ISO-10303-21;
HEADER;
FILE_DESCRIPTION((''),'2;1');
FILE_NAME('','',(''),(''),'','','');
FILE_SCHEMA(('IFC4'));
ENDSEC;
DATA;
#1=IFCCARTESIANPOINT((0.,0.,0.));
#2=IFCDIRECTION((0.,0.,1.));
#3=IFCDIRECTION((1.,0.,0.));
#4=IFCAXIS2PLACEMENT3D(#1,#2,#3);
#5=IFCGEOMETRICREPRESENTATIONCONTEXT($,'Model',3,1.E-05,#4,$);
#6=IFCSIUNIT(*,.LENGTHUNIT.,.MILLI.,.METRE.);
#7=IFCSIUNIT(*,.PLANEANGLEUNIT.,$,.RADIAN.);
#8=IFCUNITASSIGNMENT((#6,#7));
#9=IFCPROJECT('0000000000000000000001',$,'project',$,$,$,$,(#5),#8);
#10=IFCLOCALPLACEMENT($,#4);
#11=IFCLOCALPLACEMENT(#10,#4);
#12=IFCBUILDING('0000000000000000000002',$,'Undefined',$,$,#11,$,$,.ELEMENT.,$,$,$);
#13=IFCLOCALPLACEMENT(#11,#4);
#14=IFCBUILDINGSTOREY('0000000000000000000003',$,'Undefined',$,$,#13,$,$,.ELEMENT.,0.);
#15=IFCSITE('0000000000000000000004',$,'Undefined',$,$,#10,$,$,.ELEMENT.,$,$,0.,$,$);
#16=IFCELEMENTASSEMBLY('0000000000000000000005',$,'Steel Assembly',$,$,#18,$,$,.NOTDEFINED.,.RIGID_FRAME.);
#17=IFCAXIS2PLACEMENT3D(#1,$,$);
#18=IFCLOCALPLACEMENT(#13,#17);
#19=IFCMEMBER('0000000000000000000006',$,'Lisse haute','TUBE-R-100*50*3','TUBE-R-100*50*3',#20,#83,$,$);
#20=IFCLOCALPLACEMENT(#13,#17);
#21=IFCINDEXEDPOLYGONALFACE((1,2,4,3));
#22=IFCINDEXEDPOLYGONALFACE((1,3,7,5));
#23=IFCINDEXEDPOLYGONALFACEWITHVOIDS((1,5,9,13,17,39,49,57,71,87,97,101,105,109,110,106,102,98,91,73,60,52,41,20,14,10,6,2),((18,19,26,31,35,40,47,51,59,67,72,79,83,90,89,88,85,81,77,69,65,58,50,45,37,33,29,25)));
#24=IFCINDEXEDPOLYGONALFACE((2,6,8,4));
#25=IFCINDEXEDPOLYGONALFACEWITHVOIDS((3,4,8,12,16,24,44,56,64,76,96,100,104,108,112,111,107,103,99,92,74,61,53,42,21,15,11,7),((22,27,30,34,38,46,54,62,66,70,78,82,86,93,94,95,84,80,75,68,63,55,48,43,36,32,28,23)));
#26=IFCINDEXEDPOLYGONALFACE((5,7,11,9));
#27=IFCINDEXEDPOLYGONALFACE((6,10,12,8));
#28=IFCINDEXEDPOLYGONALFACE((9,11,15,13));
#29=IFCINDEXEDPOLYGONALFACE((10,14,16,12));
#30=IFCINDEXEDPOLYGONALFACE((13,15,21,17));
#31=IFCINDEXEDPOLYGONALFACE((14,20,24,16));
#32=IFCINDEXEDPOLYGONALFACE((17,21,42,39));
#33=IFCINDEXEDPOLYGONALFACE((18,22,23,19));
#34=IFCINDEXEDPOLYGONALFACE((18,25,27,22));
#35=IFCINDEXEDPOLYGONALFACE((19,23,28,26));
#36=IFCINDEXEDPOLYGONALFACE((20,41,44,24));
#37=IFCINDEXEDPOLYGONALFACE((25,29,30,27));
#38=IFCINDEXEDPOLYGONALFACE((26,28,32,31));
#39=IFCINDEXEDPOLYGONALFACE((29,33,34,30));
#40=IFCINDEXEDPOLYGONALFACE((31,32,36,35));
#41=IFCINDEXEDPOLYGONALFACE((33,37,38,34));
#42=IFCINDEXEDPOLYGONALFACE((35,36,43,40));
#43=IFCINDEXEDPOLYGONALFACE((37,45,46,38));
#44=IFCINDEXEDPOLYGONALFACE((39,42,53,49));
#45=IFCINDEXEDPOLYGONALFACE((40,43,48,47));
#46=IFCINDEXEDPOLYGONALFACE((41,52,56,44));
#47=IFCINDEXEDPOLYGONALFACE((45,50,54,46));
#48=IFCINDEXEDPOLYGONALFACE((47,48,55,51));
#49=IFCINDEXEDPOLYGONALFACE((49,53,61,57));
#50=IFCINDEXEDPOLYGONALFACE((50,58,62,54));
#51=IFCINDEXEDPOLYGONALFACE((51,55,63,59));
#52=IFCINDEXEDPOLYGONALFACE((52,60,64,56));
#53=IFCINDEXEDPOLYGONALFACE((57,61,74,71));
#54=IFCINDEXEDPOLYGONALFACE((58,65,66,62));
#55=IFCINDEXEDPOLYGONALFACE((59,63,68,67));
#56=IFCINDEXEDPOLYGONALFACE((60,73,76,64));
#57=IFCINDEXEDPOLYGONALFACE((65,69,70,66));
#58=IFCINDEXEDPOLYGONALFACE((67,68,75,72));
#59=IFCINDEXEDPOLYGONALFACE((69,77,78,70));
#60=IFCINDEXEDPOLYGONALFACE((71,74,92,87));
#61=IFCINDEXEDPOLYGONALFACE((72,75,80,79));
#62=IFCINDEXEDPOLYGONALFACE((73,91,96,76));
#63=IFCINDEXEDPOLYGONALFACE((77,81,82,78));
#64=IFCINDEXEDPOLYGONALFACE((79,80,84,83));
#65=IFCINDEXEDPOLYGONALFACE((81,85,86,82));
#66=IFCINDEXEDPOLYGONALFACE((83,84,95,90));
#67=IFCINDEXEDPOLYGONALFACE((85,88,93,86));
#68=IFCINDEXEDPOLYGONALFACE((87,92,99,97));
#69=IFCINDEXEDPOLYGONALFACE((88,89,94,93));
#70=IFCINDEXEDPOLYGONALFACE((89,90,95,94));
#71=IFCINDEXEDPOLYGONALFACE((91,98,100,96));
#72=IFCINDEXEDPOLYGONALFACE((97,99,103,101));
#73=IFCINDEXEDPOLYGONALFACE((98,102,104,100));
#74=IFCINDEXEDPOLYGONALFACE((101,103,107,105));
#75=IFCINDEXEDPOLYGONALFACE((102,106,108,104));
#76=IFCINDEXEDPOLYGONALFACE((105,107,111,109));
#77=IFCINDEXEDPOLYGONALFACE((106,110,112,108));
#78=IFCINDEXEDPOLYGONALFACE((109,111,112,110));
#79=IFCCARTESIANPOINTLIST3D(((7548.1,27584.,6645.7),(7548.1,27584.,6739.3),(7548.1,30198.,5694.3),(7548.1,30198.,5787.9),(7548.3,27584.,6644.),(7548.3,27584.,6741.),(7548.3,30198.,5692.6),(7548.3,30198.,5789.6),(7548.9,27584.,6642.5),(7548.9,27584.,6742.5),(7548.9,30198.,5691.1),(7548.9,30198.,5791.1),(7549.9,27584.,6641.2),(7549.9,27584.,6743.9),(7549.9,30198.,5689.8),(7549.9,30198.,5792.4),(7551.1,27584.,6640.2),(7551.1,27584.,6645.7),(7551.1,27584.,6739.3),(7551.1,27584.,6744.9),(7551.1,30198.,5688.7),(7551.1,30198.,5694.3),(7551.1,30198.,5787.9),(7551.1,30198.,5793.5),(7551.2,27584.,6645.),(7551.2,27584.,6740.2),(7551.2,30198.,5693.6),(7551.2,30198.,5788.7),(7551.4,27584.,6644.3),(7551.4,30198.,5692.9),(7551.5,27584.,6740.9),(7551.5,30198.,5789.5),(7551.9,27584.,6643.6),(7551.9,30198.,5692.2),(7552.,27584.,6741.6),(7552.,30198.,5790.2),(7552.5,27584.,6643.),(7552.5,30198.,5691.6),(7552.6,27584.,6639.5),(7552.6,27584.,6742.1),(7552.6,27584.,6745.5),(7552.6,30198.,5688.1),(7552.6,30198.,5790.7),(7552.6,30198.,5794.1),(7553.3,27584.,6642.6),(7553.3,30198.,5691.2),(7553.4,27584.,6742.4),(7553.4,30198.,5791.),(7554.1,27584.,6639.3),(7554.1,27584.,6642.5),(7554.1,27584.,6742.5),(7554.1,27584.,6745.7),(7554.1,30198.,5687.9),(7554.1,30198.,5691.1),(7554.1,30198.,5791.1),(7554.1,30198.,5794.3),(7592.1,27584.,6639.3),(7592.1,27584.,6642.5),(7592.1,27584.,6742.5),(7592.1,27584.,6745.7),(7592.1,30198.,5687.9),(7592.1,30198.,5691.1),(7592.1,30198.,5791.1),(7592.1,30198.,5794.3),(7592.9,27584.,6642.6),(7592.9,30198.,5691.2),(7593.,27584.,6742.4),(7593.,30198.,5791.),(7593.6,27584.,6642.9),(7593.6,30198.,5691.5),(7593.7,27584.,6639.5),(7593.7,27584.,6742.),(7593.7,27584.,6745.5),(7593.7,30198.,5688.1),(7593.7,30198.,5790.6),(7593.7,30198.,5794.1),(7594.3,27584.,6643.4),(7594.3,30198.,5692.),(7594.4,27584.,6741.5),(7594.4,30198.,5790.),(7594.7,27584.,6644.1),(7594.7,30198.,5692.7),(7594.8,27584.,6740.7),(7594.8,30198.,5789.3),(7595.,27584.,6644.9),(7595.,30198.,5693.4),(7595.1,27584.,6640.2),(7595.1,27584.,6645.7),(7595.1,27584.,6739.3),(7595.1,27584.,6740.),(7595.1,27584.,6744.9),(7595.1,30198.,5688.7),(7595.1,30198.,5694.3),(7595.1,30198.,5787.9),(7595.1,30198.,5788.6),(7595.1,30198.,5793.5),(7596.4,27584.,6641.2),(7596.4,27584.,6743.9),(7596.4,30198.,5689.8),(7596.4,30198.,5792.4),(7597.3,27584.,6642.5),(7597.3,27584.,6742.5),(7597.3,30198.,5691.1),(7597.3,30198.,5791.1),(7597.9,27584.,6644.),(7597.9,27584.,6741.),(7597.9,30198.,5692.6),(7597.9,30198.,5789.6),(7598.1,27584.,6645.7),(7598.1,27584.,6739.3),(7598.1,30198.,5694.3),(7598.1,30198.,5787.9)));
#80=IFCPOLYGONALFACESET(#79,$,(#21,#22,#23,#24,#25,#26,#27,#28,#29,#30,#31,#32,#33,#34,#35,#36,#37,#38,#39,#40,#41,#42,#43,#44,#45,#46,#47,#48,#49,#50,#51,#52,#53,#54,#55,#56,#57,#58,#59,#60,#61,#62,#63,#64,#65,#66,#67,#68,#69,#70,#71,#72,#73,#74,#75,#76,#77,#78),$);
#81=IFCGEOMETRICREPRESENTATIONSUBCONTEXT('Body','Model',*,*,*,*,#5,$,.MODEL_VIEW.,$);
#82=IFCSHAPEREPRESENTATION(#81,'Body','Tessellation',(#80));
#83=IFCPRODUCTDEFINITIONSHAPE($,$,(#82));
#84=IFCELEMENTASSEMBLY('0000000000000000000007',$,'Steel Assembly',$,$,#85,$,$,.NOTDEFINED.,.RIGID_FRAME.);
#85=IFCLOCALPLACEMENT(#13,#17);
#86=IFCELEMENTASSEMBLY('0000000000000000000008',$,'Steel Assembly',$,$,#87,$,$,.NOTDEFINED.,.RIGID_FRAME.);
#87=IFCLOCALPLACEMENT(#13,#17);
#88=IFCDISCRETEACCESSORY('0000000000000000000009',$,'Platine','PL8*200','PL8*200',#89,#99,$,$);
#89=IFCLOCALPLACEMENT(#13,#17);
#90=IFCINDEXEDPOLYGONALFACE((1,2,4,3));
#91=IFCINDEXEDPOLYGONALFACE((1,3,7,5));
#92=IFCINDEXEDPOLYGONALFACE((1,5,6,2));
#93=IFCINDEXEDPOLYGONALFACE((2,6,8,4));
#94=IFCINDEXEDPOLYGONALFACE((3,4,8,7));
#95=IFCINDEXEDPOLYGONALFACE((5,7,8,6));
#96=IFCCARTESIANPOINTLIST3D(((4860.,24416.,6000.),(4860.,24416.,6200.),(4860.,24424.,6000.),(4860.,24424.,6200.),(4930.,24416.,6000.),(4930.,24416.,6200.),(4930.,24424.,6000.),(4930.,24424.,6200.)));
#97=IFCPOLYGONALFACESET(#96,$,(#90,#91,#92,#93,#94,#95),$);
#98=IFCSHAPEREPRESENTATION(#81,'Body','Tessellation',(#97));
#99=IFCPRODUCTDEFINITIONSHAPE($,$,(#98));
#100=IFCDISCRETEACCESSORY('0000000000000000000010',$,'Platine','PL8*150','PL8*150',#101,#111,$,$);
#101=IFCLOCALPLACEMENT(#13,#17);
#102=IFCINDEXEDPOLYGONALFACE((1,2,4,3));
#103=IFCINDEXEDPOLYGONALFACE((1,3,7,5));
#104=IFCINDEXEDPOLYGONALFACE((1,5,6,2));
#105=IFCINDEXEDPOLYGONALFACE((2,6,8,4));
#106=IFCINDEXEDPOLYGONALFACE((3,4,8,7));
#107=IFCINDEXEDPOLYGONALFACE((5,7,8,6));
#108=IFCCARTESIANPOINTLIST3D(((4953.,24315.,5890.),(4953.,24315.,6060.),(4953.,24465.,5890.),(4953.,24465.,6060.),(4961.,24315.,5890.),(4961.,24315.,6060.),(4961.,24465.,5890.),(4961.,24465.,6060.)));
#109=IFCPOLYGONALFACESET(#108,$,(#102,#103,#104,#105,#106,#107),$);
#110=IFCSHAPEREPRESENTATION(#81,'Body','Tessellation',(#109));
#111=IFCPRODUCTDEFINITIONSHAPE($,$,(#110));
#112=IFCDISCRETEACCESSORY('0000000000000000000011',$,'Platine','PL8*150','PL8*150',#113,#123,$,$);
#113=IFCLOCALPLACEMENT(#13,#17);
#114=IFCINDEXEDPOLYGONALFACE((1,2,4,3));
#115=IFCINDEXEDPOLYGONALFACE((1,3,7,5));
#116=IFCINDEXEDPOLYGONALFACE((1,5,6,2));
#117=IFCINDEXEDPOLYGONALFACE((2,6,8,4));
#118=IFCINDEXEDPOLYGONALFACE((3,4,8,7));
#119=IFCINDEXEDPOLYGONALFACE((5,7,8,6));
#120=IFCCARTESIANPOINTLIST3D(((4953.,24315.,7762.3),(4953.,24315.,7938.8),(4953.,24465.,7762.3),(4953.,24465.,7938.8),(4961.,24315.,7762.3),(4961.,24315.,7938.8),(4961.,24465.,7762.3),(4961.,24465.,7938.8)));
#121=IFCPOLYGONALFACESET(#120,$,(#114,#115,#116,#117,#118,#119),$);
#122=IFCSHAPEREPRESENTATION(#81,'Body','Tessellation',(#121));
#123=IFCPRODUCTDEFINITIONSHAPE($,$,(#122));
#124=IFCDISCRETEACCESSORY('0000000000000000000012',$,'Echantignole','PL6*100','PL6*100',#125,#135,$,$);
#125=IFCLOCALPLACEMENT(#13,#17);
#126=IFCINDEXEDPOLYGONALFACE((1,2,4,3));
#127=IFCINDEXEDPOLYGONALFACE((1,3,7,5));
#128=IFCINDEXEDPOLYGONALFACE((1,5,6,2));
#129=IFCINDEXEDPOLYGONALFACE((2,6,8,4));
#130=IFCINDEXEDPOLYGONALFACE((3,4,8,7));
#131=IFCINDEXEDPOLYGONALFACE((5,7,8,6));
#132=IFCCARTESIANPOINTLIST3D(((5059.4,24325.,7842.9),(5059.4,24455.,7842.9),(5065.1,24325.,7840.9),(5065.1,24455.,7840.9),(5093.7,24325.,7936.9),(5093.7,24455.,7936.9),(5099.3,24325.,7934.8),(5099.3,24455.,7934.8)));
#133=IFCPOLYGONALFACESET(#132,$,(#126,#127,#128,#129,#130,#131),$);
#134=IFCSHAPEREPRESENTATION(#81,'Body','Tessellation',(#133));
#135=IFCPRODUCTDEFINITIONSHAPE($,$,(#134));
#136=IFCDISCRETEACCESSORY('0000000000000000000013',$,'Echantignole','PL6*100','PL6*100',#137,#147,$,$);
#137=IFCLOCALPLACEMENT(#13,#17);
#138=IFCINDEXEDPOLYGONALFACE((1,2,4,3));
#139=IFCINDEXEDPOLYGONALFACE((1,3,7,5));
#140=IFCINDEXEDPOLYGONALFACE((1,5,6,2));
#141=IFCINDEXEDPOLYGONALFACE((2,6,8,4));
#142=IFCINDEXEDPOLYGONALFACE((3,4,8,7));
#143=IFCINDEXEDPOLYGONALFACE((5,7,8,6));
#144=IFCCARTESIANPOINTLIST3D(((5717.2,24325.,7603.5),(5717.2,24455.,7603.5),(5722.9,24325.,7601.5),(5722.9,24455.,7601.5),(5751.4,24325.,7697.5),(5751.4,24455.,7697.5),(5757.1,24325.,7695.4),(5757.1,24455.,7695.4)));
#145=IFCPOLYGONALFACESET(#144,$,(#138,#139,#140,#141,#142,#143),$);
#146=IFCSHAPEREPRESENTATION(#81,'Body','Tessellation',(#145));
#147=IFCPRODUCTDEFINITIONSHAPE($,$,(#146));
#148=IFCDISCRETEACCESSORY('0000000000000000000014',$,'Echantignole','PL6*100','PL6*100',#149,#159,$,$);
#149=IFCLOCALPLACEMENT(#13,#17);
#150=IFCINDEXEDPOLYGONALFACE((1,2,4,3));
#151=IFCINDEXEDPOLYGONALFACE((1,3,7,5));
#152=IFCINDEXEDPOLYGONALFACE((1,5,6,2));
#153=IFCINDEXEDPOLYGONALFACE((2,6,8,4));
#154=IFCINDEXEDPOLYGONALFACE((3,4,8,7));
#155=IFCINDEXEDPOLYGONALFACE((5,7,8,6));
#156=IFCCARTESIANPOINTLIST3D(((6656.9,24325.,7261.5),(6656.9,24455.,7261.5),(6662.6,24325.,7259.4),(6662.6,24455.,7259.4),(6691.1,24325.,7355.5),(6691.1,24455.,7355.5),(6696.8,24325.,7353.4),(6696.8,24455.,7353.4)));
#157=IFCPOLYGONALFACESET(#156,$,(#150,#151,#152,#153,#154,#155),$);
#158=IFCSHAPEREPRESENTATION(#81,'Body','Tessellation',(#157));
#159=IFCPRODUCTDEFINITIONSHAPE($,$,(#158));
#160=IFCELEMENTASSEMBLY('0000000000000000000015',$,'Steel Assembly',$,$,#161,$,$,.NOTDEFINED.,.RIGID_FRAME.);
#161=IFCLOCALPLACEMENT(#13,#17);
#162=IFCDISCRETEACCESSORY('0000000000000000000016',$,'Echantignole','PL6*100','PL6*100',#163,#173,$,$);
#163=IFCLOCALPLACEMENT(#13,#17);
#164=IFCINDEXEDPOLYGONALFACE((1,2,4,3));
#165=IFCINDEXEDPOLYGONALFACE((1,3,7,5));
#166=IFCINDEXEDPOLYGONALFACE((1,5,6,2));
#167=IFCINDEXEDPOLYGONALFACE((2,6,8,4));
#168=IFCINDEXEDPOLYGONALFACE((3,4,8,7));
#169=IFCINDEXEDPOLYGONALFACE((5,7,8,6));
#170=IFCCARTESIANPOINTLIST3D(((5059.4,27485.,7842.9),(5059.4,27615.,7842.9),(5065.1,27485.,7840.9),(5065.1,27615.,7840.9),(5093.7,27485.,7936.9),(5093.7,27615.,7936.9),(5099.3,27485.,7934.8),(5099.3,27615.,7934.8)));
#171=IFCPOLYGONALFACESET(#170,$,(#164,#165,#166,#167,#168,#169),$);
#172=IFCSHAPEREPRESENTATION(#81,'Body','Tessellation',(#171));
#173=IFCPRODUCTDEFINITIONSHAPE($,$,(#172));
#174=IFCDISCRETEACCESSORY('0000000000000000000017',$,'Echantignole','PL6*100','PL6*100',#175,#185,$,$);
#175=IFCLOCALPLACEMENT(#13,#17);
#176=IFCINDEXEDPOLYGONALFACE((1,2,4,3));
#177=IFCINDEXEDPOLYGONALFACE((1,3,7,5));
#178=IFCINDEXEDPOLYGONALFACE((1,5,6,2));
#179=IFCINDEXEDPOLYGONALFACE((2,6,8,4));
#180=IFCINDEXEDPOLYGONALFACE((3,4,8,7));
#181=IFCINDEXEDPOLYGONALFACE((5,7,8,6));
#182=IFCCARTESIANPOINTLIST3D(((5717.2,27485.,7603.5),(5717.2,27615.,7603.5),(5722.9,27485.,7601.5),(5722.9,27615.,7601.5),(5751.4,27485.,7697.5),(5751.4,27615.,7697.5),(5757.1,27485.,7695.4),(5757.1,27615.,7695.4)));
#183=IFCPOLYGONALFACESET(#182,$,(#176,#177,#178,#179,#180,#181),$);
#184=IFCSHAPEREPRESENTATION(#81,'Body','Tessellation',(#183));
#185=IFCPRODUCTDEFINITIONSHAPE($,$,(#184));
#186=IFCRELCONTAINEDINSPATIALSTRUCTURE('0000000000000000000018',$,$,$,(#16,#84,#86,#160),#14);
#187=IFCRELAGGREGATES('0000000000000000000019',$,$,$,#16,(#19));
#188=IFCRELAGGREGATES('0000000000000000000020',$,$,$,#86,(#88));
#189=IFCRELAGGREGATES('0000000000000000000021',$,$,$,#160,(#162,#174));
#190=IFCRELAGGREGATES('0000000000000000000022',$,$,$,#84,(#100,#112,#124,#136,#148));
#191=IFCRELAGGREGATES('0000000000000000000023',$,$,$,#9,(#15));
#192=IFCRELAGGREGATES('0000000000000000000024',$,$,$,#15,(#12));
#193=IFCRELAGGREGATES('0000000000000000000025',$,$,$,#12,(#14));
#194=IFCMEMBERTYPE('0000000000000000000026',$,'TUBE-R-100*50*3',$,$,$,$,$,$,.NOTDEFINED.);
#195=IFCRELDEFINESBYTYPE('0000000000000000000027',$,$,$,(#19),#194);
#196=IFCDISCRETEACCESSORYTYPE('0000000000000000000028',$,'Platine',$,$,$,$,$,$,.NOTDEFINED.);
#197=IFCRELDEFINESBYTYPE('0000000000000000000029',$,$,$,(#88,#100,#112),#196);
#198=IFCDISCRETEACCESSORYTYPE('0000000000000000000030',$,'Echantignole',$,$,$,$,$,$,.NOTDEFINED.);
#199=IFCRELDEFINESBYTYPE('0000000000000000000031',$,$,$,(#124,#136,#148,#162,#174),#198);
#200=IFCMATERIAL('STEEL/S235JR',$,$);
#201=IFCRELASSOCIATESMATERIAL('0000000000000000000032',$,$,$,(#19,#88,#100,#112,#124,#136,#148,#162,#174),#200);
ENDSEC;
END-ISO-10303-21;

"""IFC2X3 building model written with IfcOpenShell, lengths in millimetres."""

from ifc_helpers import new_model, si_unit, frame, origin_with_axes, origin_2d_with_axis, place, context, subcontext, project, spatial, polyline, hollow_rectangle, outline, extrude, clip, halfspace, material, type_object, element, aggregate, save


model = new_model("IFC2X3")

# Units and contexts
model_context = context("Model", 3, precision=1e-05, world=origin_with_axes())
body_context = subcontext(model_context, "Body", "Model", "MODEL_VIEW")
ifc_project = project(units=[si_unit("LENGTHUNIT", "METRE", prefix="MILLI"), si_unit("PLANEANGLEUNIT", "RADIAN")], contexts=[model_context])

# Site, building, storey
site_placement = place(None, origin_with_axes())
site = spatial("IfcSite", under=ifc_project, at=site_placement, Name="Undefined", CompositionType="ELEMENT", RefElevation=0.0)
building_placement = place(site_placement, origin_with_axes())
building = spatial("IfcBuilding", under=site, at=building_placement, Name="Undefined", CompositionType="ELEMENT")
storey_placement = place(building_placement, origin_with_axes())
storey = spatial("IfcBuildingStorey", under=building, at=storey_placement, Name="Undefined", CompositionType="ELEMENT", Elevation=0.0)

# Element assembly, member
assembly_1_placement = place(storey_placement, origin_with_axes())
assembly_1 = element("IfcElementAssembly", 1, at=assembly_1_placement, inside=storey, Name="Steel Assembly", AssemblyPlace="NOTDEFINED", PredefinedType="RIGID_FRAME")
ifc_material_1 = material(Name="STEEL/S235JR")
member_type = type_object("IfcMemberType", Name="TUBE-R-100*50*3", PredefinedType="NOTDEFINED")
member_placement = place(assembly_1_placement, frame((7573.1, 27451.1, 6740.9), z_axis=(0.0, 0.34202, 0.939693), x_axis=(0.0, 0.939693, -0.34202)))
member = element("IfcMember", 2, at=member_placement, type_object=member_type, material=ifc_material_1, Name="Lisse haute", Description="TUBE-R-100*50*3", ObjectType="TUBE-R-100*50*3", context=body_context, shape_type="Clipping", body=[
    clip(clip(extrude(hollow_rectangle(XDim=50.0, YDim=100.0, WallThickness=3.0, InnerFilletRadius=3.0, OuterFilletRadius=6.0, at=origin_2d_with_axis()), frame((2960.0, 0.0, 0.0), z_axis=(-1.0, 0.0, 0.0), x_axis=(0.0, -1.0, 0.0)), (0.0, 0.0, 1.0), 2855.3), halfspace(frame((2937.4, 0.0, -38.8), z_axis=(0.939693, 0.0, 0.34202), x_axis=(0.0, -1.0, 0.0)), False)), halfspace(frame((141.5, -24.8, 0.0), z_axis=(0.939693, 0.0, 0.34202), x_axis=(-0.34202, 0.0, 0.939693)), True)),
])
aggregate(assembly_1, [member])

# Element assembly
assembly_2_placement = place(storey_placement, origin_with_axes())
assembly_2 = element("IfcElementAssembly", 3, at=assembly_2_placement, inside=storey, Name="Steel Assembly", AssemblyPlace="NOTDEFINED", PredefinedType="RIGID_FRAME")

# Element assembly, discrete accessory
assembly_3_placement = place(storey_placement, origin_with_axes())
assembly_3 = element("IfcElementAssembly", 4, at=assembly_3_placement, inside=storey, Name="Steel Assembly", AssemblyPlace="NOTDEFINED", PredefinedType="RIGID_FRAME")
discrete_accessory_type_1 = type_object("IfcDiscreteAccessoryType", Name="Platine")
discrete_accessory_1_placement = place(assembly_3_placement, frame((4930.0, 24420.0, 6100.0), z_axis=(0.0, 1.0, 0.0), x_axis=(-1.0, 0.0, 0.0)))
discrete_accessory_1 = element("IfcDiscreteAccessory", 5, at=discrete_accessory_1_placement, type_object=discrete_accessory_type_1, material=ifc_material_1, Name="Platine", Description="PL8*200", ObjectType="PL8*200", context=body_context, shape_type="SweptSolid", body=[
    extrude(outline(polyline([(0.0, -100.0), (0.0, 100.0), (70.0, 100.0), (70.0, -100.0), (0.0, -100.0)])), frame((0.0, 0.0, -4.0), z_axis=(0.0, 0.0, 1.0), x_axis=(1.0, 0.0, 0.0)), (0.0, 0.0, 1.0), 8.0),
])
aggregate(assembly_3, [discrete_accessory_1])

# Discrete accessories
discrete_accessory_2_placement = place(assembly_2_placement, frame((4957.0, 24390.0, 5890.0), z_axis=(1.0, 0.0, 0.000005), x_axis=(-0.000005, 0.0, 1.0)))
discrete_accessory_2 = element("IfcDiscreteAccessory", 6, at=discrete_accessory_2_placement, type_object=discrete_accessory_type_1, material=ifc_material_1, Name="Platine", Description="PL8*150", ObjectType="PL8*150", context=body_context, shape_type="SweptSolid", body=[
    extrude(outline(polyline([(170.0, 75.0), (170.0, -75.0), (0.0, -75.0), (0.0, 75.0), (170.0, 75.0)])), frame((0.0, 0.0, -4.0), z_axis=(0.0, 0.0, 1.0), x_axis=(1.0, 0.0, 0.0)), (0.0, 0.0, 1.0), 8.0),
])
discrete_accessory_3_placement = place(assembly_2_placement, frame((4957.0, 24390.0, 7762.3), z_axis=(1.0, 0.0, 0.000005), x_axis=(-0.000005, 0.0, 1.0)))
discrete_accessory_3 = element("IfcDiscreteAccessory", 7, at=discrete_accessory_3_placement, type_object=discrete_accessory_type_1, material=ifc_material_1, Name="Platine", Description="PL8*150", ObjectType="PL8*150", context=body_context, shape_type="SweptSolid", body=[
    extrude(outline(polyline([(176.4, 75.0), (176.4, -75.0), (0.0, -75.0), (0.0, 75.0), (176.4, 75.0)])), frame((0.0, 0.0, -4.0), z_axis=(0.0, 0.0, 1.0), x_axis=(1.0, 0.0, 0.0)), (0.0, 0.0, 1.0), 8.0),
])
discrete_accessory_type_2 = type_object("IfcDiscreteAccessoryType", Name="Echantignole")
discrete_accessory_4_placement = place(assembly_2_placement, frame((5079.4, 24325.0, 7888.9), z_axis=(0.939693, 0.0, -0.34202), x_axis=(0.0, 1.0, 0.0)))
discrete_accessory_4 = element("IfcDiscreteAccessory", 8, at=discrete_accessory_4_placement, type_object=discrete_accessory_type_2, material=ifc_material_1, Name="Echantignole", Description="PL6*100", ObjectType="PL6*100", context=body_context, shape_type="SweptSolid", body=[
    extrude(outline(polyline([(0.0, 50.0), (130.0, 50.0), (130.0, -50.0), (0.0, -50.0), (0.0, 50.0)])), frame((0.0, 0.0, -3.0), z_axis=(0.0, 0.0, 1.0), x_axis=(1.0, 0.0, 0.0)), (0.0, 0.0, 1.0), 6.0),
])
discrete_accessory_5_placement = place(assembly_2_placement, frame((5737.2, 24325.0, 7649.5), z_axis=(0.939693, 0.0, -0.34202), x_axis=(0.0, 1.0, 0.0)))
discrete_accessory_5 = element("IfcDiscreteAccessory", 9, at=discrete_accessory_5_placement, type_object=discrete_accessory_type_2, material=ifc_material_1, Name="Echantignole", Description="PL6*100", ObjectType="PL6*100", context=body_context, shape_type="SweptSolid", body=[
    extrude(outline(polyline([(0.0, 50.0), (130.0, 50.0), (130.0, -50.0), (0.0, -50.0), (0.0, 50.0)])), frame((0.0, 0.0, -3.0), z_axis=(0.0, 0.0, 1.0), x_axis=(1.0, 0.0, 0.0)), (0.0, 0.0, 1.0), 6.0),
])
discrete_accessory_6_placement = place(assembly_2_placement, frame((6676.8, 24325.0, 7307.5), z_axis=(0.939693, 0.0, -0.34202), x_axis=(0.0, 1.0, 0.0)))
discrete_accessory_6 = element("IfcDiscreteAccessory", 10, at=discrete_accessory_6_placement, type_object=discrete_accessory_type_2, material=ifc_material_1, Name="Echantignole", Description="PL6*100", ObjectType="PL6*100", context=body_context, shape_type="SweptSolid", body=[
    extrude(outline(polyline([(0.0, 50.0), (130.0, 50.0), (130.0, -50.0), (0.0, -50.0), (0.0, 50.0)])), frame((0.0, 0.0, -3.0), z_axis=(0.0, 0.0, 1.0), x_axis=(1.0, 0.0, 0.0)), (0.0, 0.0, 1.0), 6.0),
])

# Element assembly, discrete accessories
assembly_4_placement = place(storey_placement, origin_with_axes())
assembly_4 = element("IfcElementAssembly", 11, at=assembly_4_placement, inside=storey, Name="Steel Assembly", AssemblyPlace="NOTDEFINED", PredefinedType="RIGID_FRAME")
discrete_accessory_7_placement = place(assembly_4_placement, frame((5079.4, 27485.0, 7888.9), z_axis=(0.939693, 0.0, -0.34202), x_axis=(0.0, 1.0, 0.0)))
discrete_accessory_7 = element("IfcDiscreteAccessory", 12, at=discrete_accessory_7_placement, type_object=discrete_accessory_type_2, material=ifc_material_1, Name="Echantignole", Description="PL6*100", ObjectType="PL6*100", context=body_context, shape_type="SweptSolid", body=[
    extrude(outline(polyline([(0.0, 50.0), (130.0, 50.0), (130.0, -50.0), (0.0, -50.0), (0.0, 50.0)])), frame((0.0, 0.0, -3.0), z_axis=(0.0, 0.0, 1.0), x_axis=(1.0, 0.0, 0.0)), (0.0, 0.0, 1.0), 6.0),
])
discrete_accessory_8_placement = place(assembly_4_placement, frame((5737.2, 27485.0, 7649.5), z_axis=(0.939693, 0.0, -0.34202), x_axis=(0.0, 1.0, 0.0)))
discrete_accessory_8 = element("IfcDiscreteAccessory", 13, at=discrete_accessory_8_placement, type_object=discrete_accessory_type_2, material=ifc_material_1, Name="Echantignole", Description="PL6*100", ObjectType="PL6*100", context=body_context, shape_type="SweptSolid", body=[
    extrude(outline(polyline([(0.0, 50.0), (130.0, 50.0), (130.0, -50.0), (0.0, -50.0), (0.0, 50.0)])), frame((0.0, 0.0, -3.0), z_axis=(0.0, 0.0, 1.0), x_axis=(1.0, 0.0, 0.0)), (0.0, 0.0, 1.0), 6.0),
])
aggregate(assembly_4, [discrete_accessory_7, discrete_accessory_8])

aggregate(assembly_2, [discrete_accessory_2, discrete_accessory_3, discrete_accessory_4, discrete_accessory_5, discrete_accessory_6])

save(model, "model.ifc")
